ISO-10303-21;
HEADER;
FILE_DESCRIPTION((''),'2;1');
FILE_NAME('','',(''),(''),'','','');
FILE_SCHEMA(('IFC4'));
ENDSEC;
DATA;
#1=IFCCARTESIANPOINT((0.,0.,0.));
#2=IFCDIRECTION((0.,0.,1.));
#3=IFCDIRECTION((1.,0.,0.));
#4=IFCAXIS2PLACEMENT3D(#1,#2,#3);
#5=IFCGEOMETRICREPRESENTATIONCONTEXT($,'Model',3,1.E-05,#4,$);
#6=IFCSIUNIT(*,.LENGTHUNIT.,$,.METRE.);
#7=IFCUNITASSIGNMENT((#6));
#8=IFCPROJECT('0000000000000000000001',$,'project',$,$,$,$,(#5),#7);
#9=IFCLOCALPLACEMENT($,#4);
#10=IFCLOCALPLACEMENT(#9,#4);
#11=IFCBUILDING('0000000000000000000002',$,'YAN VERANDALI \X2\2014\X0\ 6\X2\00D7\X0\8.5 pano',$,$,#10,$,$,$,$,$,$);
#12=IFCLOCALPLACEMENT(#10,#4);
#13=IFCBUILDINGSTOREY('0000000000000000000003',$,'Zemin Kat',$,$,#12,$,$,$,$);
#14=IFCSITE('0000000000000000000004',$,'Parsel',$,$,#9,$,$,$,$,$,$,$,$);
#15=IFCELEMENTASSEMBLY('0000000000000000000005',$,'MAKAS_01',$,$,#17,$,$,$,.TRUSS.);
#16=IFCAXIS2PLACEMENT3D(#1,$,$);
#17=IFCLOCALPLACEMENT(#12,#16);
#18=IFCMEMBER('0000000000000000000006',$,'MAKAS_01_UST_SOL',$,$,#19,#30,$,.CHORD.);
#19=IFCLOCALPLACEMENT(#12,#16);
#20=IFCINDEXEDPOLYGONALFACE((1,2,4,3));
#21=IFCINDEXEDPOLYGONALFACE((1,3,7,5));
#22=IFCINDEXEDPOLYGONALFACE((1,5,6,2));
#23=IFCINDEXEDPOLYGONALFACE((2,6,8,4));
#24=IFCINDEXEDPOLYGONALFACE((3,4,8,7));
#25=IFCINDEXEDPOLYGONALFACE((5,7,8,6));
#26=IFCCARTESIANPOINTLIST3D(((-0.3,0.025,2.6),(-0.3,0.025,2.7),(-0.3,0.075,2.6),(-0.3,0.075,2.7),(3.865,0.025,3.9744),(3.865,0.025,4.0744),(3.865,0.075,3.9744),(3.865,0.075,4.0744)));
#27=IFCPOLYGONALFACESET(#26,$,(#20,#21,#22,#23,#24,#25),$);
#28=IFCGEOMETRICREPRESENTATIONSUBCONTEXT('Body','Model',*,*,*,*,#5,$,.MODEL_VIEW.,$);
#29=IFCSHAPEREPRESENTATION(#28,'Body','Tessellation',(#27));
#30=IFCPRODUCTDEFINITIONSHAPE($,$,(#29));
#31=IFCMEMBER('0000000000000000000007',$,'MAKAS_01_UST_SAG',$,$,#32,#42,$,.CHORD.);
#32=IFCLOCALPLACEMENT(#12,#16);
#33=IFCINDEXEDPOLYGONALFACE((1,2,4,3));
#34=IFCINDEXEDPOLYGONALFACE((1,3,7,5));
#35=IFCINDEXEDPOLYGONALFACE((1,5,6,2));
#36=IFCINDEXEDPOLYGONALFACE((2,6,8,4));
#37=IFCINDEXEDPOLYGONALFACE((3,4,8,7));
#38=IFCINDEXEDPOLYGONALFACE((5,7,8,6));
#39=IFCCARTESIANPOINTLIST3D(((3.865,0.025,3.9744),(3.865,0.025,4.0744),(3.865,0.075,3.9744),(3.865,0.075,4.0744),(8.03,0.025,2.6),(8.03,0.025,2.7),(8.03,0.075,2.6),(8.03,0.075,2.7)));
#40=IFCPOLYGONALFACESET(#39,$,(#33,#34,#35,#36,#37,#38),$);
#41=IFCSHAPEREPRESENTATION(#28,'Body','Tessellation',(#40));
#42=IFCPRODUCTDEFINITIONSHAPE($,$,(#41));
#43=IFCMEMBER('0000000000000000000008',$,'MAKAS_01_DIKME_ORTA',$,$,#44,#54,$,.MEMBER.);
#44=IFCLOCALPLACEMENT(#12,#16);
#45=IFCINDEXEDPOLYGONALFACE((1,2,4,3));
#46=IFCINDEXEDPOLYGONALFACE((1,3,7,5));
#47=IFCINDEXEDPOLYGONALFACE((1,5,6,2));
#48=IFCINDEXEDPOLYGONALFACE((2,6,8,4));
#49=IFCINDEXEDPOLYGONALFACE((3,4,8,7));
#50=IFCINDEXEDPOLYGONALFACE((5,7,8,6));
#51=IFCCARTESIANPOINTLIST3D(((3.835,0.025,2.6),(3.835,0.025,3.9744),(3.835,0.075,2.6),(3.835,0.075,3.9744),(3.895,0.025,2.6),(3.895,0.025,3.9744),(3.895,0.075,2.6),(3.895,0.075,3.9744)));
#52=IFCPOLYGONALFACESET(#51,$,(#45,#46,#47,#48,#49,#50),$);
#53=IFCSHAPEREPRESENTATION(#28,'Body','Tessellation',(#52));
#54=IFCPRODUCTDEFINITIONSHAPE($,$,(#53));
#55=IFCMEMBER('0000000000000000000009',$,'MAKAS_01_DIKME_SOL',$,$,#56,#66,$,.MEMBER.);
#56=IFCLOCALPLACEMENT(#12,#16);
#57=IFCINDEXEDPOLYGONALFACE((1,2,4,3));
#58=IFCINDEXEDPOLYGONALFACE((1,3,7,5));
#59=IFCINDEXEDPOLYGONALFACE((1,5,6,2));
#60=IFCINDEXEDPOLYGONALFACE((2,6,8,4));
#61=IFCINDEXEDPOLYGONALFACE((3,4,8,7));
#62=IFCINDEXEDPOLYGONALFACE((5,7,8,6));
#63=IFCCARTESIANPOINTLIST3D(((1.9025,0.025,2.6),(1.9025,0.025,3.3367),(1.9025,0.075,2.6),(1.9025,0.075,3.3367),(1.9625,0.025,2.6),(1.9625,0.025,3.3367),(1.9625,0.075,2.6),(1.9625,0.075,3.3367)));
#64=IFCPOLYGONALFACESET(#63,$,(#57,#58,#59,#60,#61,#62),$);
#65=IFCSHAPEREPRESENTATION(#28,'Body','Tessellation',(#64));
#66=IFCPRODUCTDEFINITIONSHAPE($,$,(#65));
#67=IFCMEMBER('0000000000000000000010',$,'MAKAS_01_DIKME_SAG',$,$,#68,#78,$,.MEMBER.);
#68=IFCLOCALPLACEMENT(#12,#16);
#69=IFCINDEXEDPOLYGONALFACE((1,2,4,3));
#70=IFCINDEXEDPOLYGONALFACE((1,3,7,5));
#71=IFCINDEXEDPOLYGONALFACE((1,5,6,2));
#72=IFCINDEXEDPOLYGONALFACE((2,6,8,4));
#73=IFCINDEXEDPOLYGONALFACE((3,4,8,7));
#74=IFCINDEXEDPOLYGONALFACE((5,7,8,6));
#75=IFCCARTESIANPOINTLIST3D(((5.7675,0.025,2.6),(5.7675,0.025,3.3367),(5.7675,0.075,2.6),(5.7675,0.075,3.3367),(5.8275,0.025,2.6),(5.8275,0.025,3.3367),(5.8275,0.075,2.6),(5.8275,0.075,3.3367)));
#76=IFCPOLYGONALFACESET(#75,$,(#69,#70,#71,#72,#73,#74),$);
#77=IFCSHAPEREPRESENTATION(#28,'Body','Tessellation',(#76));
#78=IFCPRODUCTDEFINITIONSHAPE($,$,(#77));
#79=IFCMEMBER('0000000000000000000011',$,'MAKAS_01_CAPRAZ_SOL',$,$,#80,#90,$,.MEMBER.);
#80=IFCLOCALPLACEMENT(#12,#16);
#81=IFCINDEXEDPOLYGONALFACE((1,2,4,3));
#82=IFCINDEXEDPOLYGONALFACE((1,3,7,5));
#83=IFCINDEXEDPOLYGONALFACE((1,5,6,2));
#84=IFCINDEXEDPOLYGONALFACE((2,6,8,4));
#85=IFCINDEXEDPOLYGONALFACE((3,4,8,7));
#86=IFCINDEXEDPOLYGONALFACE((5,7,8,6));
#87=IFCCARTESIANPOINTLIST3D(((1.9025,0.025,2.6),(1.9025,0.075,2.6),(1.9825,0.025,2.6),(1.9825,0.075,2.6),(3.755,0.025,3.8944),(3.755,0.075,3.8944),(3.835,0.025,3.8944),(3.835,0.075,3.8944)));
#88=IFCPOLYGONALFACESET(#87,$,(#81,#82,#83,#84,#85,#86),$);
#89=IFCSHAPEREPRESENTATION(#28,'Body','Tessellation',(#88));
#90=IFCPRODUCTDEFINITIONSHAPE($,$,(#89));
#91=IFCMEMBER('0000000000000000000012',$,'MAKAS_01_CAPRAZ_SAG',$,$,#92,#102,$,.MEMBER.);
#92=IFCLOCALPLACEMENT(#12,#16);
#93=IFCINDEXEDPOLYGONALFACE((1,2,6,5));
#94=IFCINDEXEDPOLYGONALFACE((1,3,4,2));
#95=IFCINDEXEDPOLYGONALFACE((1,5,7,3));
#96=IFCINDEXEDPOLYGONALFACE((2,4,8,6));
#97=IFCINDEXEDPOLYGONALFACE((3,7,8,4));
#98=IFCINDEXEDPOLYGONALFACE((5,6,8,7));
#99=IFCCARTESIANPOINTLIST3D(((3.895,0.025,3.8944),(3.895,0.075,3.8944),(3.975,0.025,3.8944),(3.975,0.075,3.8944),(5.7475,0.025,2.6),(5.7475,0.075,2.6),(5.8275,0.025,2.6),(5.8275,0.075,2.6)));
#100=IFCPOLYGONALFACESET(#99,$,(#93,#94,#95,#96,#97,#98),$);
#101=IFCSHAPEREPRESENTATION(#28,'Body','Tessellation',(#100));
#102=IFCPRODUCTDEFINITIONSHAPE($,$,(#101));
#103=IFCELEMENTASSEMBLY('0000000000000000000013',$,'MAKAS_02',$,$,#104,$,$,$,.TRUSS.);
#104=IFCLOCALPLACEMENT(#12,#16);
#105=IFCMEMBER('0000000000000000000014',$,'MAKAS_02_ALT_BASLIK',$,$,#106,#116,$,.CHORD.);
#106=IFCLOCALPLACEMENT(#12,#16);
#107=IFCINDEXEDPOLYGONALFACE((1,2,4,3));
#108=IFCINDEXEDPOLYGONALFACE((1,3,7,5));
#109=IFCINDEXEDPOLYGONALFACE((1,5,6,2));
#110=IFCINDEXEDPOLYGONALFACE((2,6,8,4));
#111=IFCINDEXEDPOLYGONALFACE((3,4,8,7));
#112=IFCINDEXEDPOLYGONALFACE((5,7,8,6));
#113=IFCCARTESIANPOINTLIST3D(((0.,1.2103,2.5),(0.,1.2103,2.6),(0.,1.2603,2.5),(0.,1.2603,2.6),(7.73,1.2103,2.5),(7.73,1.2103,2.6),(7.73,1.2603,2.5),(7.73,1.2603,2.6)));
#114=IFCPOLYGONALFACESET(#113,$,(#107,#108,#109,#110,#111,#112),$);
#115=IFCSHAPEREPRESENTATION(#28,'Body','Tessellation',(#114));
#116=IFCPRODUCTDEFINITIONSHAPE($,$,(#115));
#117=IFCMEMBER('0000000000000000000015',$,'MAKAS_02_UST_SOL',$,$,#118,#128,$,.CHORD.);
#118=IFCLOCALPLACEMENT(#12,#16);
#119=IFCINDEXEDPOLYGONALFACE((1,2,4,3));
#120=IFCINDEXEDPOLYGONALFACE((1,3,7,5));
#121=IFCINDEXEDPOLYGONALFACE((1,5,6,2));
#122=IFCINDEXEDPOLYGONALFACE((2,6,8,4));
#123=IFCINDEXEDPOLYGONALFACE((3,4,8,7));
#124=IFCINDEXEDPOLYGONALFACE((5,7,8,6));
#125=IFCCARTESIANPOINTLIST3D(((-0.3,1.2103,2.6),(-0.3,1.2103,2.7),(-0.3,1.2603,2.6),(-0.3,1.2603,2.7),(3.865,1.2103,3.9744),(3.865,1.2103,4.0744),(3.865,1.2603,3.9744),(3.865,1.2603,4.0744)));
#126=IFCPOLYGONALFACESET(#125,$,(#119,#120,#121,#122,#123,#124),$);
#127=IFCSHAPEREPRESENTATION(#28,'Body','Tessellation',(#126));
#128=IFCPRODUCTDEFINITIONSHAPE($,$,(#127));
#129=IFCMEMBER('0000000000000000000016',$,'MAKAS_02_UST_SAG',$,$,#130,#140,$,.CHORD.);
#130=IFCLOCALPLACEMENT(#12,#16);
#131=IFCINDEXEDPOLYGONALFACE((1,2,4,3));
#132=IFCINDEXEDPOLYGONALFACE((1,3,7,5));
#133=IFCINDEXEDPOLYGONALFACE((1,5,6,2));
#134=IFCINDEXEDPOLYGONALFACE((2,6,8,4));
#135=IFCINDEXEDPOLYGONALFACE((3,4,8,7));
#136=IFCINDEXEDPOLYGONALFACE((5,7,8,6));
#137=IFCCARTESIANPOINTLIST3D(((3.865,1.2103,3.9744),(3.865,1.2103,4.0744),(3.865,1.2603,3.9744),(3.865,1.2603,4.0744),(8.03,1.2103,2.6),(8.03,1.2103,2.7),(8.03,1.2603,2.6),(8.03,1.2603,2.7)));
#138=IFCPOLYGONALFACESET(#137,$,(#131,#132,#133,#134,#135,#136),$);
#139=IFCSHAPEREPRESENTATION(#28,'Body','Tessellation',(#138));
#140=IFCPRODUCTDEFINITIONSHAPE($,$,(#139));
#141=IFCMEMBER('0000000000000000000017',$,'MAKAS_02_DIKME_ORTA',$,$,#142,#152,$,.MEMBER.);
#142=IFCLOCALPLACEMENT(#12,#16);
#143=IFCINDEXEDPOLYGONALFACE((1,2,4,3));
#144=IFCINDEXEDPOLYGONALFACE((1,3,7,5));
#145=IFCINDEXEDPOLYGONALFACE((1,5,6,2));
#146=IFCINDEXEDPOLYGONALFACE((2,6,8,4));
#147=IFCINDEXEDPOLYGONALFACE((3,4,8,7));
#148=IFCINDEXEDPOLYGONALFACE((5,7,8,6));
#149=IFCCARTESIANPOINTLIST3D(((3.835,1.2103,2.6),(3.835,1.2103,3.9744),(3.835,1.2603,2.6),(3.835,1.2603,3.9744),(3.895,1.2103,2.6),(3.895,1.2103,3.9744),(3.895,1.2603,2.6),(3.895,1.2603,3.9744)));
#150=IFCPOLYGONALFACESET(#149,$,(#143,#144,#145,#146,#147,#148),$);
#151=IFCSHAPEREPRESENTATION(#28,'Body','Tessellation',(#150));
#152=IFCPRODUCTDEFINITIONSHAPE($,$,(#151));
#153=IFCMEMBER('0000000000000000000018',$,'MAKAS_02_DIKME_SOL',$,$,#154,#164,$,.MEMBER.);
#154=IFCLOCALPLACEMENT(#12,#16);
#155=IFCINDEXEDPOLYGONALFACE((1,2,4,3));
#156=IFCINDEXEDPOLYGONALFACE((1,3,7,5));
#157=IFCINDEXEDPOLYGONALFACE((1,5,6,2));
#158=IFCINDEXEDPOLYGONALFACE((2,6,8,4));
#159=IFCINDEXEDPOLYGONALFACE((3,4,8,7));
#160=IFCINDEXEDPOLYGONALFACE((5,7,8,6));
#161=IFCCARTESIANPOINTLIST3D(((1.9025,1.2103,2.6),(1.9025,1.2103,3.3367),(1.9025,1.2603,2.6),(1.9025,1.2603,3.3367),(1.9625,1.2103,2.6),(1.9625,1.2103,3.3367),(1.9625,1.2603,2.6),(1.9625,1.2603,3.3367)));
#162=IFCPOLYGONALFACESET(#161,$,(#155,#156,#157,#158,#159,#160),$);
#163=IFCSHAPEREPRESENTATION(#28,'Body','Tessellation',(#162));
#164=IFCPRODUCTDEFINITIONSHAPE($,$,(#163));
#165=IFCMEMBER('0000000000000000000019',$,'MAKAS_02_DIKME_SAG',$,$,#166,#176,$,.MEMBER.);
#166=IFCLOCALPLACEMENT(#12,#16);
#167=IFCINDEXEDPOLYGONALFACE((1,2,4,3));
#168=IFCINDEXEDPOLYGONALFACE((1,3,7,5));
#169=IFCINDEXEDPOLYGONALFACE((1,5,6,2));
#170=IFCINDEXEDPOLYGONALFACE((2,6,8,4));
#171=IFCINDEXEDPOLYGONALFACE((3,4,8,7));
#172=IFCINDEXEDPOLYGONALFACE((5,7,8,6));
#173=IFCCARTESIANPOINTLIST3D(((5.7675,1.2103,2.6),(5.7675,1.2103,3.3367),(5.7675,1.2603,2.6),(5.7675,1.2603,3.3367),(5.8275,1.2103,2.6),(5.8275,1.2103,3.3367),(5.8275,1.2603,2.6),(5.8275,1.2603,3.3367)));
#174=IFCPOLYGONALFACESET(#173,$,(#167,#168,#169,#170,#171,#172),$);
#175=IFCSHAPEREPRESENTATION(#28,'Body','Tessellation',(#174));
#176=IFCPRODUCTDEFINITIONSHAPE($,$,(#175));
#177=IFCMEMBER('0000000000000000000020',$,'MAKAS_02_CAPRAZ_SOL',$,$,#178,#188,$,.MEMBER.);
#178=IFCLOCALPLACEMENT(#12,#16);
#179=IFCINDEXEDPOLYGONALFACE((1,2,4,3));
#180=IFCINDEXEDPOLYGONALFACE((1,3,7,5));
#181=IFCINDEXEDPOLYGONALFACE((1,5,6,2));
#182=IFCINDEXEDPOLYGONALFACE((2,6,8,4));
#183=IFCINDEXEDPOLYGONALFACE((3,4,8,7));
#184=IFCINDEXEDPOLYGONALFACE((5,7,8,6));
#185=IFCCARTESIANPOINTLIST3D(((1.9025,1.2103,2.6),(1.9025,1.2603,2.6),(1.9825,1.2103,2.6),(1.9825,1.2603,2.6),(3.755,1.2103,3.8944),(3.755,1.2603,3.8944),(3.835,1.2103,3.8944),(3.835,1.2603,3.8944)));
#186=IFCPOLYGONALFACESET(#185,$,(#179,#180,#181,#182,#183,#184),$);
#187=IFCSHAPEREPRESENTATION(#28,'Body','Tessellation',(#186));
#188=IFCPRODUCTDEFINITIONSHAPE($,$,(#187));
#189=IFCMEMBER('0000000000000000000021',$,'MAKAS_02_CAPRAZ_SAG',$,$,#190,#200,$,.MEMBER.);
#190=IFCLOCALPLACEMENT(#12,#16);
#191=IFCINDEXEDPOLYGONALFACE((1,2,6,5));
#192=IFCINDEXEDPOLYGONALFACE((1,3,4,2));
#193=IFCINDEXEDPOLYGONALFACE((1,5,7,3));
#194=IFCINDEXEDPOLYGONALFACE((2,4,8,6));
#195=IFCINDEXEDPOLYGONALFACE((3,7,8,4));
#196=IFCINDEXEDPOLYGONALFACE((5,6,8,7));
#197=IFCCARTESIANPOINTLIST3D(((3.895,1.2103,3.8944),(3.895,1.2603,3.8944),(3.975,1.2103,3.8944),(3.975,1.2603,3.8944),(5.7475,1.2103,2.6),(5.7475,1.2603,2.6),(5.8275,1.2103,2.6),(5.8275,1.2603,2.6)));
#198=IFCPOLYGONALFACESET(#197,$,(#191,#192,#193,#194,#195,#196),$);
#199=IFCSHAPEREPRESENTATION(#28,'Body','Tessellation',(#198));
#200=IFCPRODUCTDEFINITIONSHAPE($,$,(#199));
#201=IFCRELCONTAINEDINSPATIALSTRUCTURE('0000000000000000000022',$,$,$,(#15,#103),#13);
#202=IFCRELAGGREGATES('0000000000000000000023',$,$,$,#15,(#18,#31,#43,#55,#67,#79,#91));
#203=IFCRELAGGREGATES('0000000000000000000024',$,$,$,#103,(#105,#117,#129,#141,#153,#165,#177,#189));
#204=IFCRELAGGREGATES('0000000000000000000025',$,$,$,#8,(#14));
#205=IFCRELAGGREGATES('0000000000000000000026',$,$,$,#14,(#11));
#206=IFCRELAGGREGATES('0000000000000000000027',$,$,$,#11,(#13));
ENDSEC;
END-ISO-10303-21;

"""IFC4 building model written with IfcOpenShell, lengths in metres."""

from ifc_helpers import new_model, si_unit, frame, origin_with_axes, place, context, subcontext, project, spatial, line, indexed_curve, outline, extrude, element, aggregate, save


model = new_model("IFC4")

# Units and contexts
model_context = context("Model", 3, precision=1e-05, world=origin_with_axes())
body_context = subcontext(model_context, "Body", "Model", "MODEL_VIEW")
ifc_project = project(units=[si_unit("LENGTHUNIT", "METRE")], contexts=[model_context])

# Site, building, storey
site_placement = place(None, origin_with_axes())
site = spatial("IfcSite", under=ifc_project, at=site_placement, Name="Parsel")
building_placement = place(site_placement, origin_with_axes())
building = spatial("IfcBuilding", under=site, at=building_placement, Name="YAN VERANDALI — 6×8.5 pano")
storey_placement = place(building_placement, origin_with_axes())
storey = spatial("IfcBuildingStorey", under=building, at=storey_placement, Name="Zemin Kat")

# Element assemblies, members
assembly_1_placement = place(storey_placement, origin_with_axes())
assembly_1 = element("IfcElementAssembly", 1, at=assembly_1_placement, inside=storey, Name="MAKAS_01", PredefinedType="TRUSS")
member_1_placement = place(assembly_1_placement, origin_with_axes())
member_1 = element("IfcMember", 2, at=member_1_placement, Name="MAKAS_01_UST_SOL", PredefinedType="CHORD", context=body_context, shape_type="SweptSolid", body=[
    extrude(outline(indexed_curve([(-0.3, 2.6), (3.865, 3.9745), (3.865, 4.0744), (-0.3, 2.7)], segments=[line(1, 2, 3, 4, 1)])), frame((0.0, 0.075, 0.0), z_axis=(0.0, -1.0, 0.0), x_axis=(1.0, 0.0, 0.0)), (0.0, 0.0, 1.0), 0.05),
])
member_2_placement = place(assembly_1_placement, origin_with_axes())
member_2 = element("IfcMember", 3, at=member_2_placement, Name="MAKAS_01_UST_SAG", PredefinedType="CHORD", context=body_context, shape_type="SweptSolid", body=[
    extrude(outline(indexed_curve([(3.865, 3.9745), (8.03, 2.6), (8.03, 2.7), (3.865, 4.0744)], segments=[line(1, 2, 3, 4, 1)])), frame((0.0, 0.075, 0.0), z_axis=(0.0, -1.0, 0.0), x_axis=(1.0, 0.0, 0.0)), (0.0, 0.0, 1.0), 0.05),
])
member_3_placement = place(assembly_1_placement, origin_with_axes())
member_3 = element("IfcMember", 4, at=member_3_placement, Name="MAKAS_01_DIKME_ORTA", PredefinedType="MEMBER", context=body_context, shape_type="SweptSolid", body=[
    extrude(outline(indexed_curve([(3.835, 2.6), (3.895, 2.6), (3.895, 3.9745), (3.835, 3.9745)], segments=[line(1, 2, 3, 4, 1)])), frame((0.0, 0.075, 0.0), z_axis=(0.0, -1.0, 0.0), x_axis=(1.0, 0.0, 0.0)), (0.0, 0.0, 1.0), 0.05),
])
member_4_placement = place(assembly_1_placement, origin_with_axes())
member_4 = element("IfcMember", 5, at=member_4_placement, Name="MAKAS_01_DIKME_SOL", PredefinedType="MEMBER", context=body_context, shape_type="SweptSolid", body=[
    extrude(outline(indexed_curve([(1.9025, 2.6), (1.9625, 2.6), (1.9625, 3.3367), (1.9025, 3.3367)], segments=[line(1, 2, 3, 4, 1)])), frame((0.0, 0.075, 0.0), z_axis=(0.0, -1.0, 0.0), x_axis=(1.0, 0.0, 0.0)), (0.0, 0.0, 1.0), 0.05),
])
member_5_placement = place(assembly_1_placement, origin_with_axes())
member_5 = element("IfcMember", 6, at=member_5_placement, Name="MAKAS_01_DIKME_SAG", PredefinedType="MEMBER", context=body_context, shape_type="SweptSolid", body=[
    extrude(outline(indexed_curve([(5.7675, 2.6), (5.8275, 2.6), (5.8275, 3.3367), (5.7675, 3.3367)], segments=[line(1, 2, 3, 4, 1)])), frame((0.0, 0.075, 0.0), z_axis=(0.0, -1.0, 0.0), x_axis=(1.0, 0.0, 0.0)), (0.0, 0.0, 1.0), 0.05),
])
member_6_placement = place(assembly_1_placement, origin_with_axes())
member_6 = element("IfcMember", 7, at=member_6_placement, Name="MAKAS_01_CAPRAZ_SOL", PredefinedType="MEMBER", context=body_context, shape_type="SweptSolid", body=[
    extrude(outline(indexed_curve([(1.9025, 2.6), (1.9825, 2.6), (3.835, 3.8944), (3.755, 3.8944)], segments=[line(1, 2, 3, 4, 1)])), frame((0.0, 0.075, 0.0), z_axis=(0.0, -1.0, 0.0), x_axis=(1.0, 0.0, 0.0)), (0.0, 0.0, 1.0), 0.05),
])
member_7_placement = place(assembly_1_placement, origin_with_axes())
member_7 = element("IfcMember", 8, at=member_7_placement, Name="MAKAS_01_CAPRAZ_SAG", PredefinedType="MEMBER", context=body_context, shape_type="SweptSolid", body=[
    extrude(outline(indexed_curve([(5.7475, 2.6), (5.8275, 2.6), (3.975, 3.8944), (3.895, 3.8944)], segments=[line(1, 2, 3, 4, 1)])), frame((0.0, 0.075, 0.0), z_axis=(0.0, -1.0, 0.0), x_axis=(1.0, 0.0, 0.0)), (0.0, 0.0, 1.0), 0.05),
])
aggregate(assembly_1, [member_1, member_2, member_3, member_4, member_5, member_6, member_7])
assembly_2_placement = place(storey_placement, origin_with_axes())
assembly_2 = element("IfcElementAssembly", 9, at=assembly_2_placement, inside=storey, Name="MAKAS_02", PredefinedType="TRUSS")
member_8_placement = place(assembly_2_placement, origin_with_axes())
member_8 = element("IfcMember", 10, at=member_8_placement, Name="MAKAS_02_ALT_BASLIK", PredefinedType="CHORD", context=body_context, shape_type="SweptSolid", body=[
    extrude(outline(indexed_curve([(0.0, 2.5), (7.73, 2.5), (7.73, 2.6), (0.0, 2.6)], segments=[line(1, 2, 3, 4, 1)])), frame((0.0, 1.2603, 0.0), z_axis=(0.0, -1.0, 0.0), x_axis=(1.0, 0.0, 0.0)), (0.0, 0.0, 1.0), 0.05),
])
member_9_placement = place(assembly_2_placement, origin_with_axes())
member_9 = element("IfcMember", 11, at=member_9_placement, Name="MAKAS_02_UST_SOL", PredefinedType="CHORD", context=body_context, shape_type="SweptSolid", body=[
    extrude(outline(indexed_curve([(-0.3, 2.6), (3.865, 3.9745), (3.865, 4.0744), (-0.3, 2.7)], segments=[line(1, 2, 3, 4, 1)])), frame((0.0, 1.2603, 0.0), z_axis=(0.0, -1.0, 0.0), x_axis=(1.0, 0.0, 0.0)), (0.0, 0.0, 1.0), 0.05),
])
member_10_placement = place(assembly_2_placement, origin_with_axes())
member_10 = element("IfcMember", 12, at=member_10_placement, Name="MAKAS_02_UST_SAG", PredefinedType="CHORD", context=body_context, shape_type="SweptSolid", body=[
    extrude(outline(indexed_curve([(3.865, 3.9745), (8.03, 2.6), (8.03, 2.7), (3.865, 4.0744)], segments=[line(1, 2, 3, 4, 1)])), frame((0.0, 1.2603, 0.0), z_axis=(0.0, -1.0, 0.0), x_axis=(1.0, 0.0, 0.0)), (0.0, 0.0, 1.0), 0.05),
])
member_11_placement = place(assembly_2_placement, origin_with_axes())
member_11 = element("IfcMember", 13, at=member_11_placement, Name="MAKAS_02_DIKME_ORTA", PredefinedType="MEMBER", context=body_context, shape_type="SweptSolid", body=[
    extrude(outline(indexed_curve([(3.835, 2.6), (3.895, 2.6), (3.895, 3.9745), (3.835, 3.9745)], segments=[line(1, 2, 3, 4, 1)])), frame((0.0, 1.2603, 0.0), z_axis=(0.0, -1.0, 0.0), x_axis=(1.0, 0.0, 0.0)), (0.0, 0.0, 1.0), 0.05),
])
member_12_placement = place(assembly_2_placement, origin_with_axes())
member_12 = element("IfcMember", 14, at=member_12_placement, Name="MAKAS_02_DIKME_SOL", PredefinedType="MEMBER", context=body_context, shape_type="SweptSolid", body=[
    extrude(outline(indexed_curve([(1.9025, 2.6), (1.9625, 2.6), (1.9625, 3.3367), (1.9025, 3.3367)], segments=[line(1, 2, 3, 4, 1)])), frame((0.0, 1.2603, 0.0), z_axis=(0.0, -1.0, 0.0), x_axis=(1.0, 0.0, 0.0)), (0.0, 0.0, 1.0), 0.05),
])
member_13_placement = place(assembly_2_placement, origin_with_axes())
member_13 = element("IfcMember", 15, at=member_13_placement, Name="MAKAS_02_DIKME_SAG", PredefinedType="MEMBER", context=body_context, shape_type="SweptSolid", body=[
    extrude(outline(indexed_curve([(5.7675, 2.6), (5.8275, 2.6), (5.8275, 3.3367), (5.7675, 3.3367)], segments=[line(1, 2, 3, 4, 1)])), frame((0.0, 1.2603, 0.0), z_axis=(0.0, -1.0, 0.0), x_axis=(1.0, 0.0, 0.0)), (0.0, 0.0, 1.0), 0.05),
])
member_14_placement = place(assembly_2_placement, origin_with_axes())
member_14 = element("IfcMember", 16, at=member_14_placement, Name="MAKAS_02_CAPRAZ_SOL", PredefinedType="MEMBER", context=body_context, shape_type="SweptSolid", body=[
    extrude(outline(indexed_curve([(1.9025, 2.6), (1.9825, 2.6), (3.835, 3.8944), (3.755, 3.8944)], segments=[line(1, 2, 3, 4, 1)])), frame((0.0, 1.2603, 0.0), z_axis=(0.0, -1.0, 0.0), x_axis=(1.0, 0.0, 0.0)), (0.0, 0.0, 1.0), 0.05),
])
member_15_placement = place(assembly_2_placement, origin_with_axes())
member_15 = element("IfcMember", 17, at=member_15_placement, Name="MAKAS_02_CAPRAZ_SAG", PredefinedType="MEMBER", context=body_context, shape_type="SweptSolid", body=[
    extrude(outline(indexed_curve([(5.7475, 2.6), (5.8275, 2.6), (3.975, 3.8944), (3.895, 3.8944)], segments=[line(1, 2, 3, 4, 1)])), frame((0.0, 1.2603, 0.0), z_axis=(0.0, -1.0, 0.0), x_axis=(1.0, 0.0, 0.0)), (0.0, 0.0, 1.0), 0.05),
])
aggregate(assembly_2, [member_8, member_9, member_10, member_11, member_12, member_13, member_14, member_15])

save(model, "model.ifc")
